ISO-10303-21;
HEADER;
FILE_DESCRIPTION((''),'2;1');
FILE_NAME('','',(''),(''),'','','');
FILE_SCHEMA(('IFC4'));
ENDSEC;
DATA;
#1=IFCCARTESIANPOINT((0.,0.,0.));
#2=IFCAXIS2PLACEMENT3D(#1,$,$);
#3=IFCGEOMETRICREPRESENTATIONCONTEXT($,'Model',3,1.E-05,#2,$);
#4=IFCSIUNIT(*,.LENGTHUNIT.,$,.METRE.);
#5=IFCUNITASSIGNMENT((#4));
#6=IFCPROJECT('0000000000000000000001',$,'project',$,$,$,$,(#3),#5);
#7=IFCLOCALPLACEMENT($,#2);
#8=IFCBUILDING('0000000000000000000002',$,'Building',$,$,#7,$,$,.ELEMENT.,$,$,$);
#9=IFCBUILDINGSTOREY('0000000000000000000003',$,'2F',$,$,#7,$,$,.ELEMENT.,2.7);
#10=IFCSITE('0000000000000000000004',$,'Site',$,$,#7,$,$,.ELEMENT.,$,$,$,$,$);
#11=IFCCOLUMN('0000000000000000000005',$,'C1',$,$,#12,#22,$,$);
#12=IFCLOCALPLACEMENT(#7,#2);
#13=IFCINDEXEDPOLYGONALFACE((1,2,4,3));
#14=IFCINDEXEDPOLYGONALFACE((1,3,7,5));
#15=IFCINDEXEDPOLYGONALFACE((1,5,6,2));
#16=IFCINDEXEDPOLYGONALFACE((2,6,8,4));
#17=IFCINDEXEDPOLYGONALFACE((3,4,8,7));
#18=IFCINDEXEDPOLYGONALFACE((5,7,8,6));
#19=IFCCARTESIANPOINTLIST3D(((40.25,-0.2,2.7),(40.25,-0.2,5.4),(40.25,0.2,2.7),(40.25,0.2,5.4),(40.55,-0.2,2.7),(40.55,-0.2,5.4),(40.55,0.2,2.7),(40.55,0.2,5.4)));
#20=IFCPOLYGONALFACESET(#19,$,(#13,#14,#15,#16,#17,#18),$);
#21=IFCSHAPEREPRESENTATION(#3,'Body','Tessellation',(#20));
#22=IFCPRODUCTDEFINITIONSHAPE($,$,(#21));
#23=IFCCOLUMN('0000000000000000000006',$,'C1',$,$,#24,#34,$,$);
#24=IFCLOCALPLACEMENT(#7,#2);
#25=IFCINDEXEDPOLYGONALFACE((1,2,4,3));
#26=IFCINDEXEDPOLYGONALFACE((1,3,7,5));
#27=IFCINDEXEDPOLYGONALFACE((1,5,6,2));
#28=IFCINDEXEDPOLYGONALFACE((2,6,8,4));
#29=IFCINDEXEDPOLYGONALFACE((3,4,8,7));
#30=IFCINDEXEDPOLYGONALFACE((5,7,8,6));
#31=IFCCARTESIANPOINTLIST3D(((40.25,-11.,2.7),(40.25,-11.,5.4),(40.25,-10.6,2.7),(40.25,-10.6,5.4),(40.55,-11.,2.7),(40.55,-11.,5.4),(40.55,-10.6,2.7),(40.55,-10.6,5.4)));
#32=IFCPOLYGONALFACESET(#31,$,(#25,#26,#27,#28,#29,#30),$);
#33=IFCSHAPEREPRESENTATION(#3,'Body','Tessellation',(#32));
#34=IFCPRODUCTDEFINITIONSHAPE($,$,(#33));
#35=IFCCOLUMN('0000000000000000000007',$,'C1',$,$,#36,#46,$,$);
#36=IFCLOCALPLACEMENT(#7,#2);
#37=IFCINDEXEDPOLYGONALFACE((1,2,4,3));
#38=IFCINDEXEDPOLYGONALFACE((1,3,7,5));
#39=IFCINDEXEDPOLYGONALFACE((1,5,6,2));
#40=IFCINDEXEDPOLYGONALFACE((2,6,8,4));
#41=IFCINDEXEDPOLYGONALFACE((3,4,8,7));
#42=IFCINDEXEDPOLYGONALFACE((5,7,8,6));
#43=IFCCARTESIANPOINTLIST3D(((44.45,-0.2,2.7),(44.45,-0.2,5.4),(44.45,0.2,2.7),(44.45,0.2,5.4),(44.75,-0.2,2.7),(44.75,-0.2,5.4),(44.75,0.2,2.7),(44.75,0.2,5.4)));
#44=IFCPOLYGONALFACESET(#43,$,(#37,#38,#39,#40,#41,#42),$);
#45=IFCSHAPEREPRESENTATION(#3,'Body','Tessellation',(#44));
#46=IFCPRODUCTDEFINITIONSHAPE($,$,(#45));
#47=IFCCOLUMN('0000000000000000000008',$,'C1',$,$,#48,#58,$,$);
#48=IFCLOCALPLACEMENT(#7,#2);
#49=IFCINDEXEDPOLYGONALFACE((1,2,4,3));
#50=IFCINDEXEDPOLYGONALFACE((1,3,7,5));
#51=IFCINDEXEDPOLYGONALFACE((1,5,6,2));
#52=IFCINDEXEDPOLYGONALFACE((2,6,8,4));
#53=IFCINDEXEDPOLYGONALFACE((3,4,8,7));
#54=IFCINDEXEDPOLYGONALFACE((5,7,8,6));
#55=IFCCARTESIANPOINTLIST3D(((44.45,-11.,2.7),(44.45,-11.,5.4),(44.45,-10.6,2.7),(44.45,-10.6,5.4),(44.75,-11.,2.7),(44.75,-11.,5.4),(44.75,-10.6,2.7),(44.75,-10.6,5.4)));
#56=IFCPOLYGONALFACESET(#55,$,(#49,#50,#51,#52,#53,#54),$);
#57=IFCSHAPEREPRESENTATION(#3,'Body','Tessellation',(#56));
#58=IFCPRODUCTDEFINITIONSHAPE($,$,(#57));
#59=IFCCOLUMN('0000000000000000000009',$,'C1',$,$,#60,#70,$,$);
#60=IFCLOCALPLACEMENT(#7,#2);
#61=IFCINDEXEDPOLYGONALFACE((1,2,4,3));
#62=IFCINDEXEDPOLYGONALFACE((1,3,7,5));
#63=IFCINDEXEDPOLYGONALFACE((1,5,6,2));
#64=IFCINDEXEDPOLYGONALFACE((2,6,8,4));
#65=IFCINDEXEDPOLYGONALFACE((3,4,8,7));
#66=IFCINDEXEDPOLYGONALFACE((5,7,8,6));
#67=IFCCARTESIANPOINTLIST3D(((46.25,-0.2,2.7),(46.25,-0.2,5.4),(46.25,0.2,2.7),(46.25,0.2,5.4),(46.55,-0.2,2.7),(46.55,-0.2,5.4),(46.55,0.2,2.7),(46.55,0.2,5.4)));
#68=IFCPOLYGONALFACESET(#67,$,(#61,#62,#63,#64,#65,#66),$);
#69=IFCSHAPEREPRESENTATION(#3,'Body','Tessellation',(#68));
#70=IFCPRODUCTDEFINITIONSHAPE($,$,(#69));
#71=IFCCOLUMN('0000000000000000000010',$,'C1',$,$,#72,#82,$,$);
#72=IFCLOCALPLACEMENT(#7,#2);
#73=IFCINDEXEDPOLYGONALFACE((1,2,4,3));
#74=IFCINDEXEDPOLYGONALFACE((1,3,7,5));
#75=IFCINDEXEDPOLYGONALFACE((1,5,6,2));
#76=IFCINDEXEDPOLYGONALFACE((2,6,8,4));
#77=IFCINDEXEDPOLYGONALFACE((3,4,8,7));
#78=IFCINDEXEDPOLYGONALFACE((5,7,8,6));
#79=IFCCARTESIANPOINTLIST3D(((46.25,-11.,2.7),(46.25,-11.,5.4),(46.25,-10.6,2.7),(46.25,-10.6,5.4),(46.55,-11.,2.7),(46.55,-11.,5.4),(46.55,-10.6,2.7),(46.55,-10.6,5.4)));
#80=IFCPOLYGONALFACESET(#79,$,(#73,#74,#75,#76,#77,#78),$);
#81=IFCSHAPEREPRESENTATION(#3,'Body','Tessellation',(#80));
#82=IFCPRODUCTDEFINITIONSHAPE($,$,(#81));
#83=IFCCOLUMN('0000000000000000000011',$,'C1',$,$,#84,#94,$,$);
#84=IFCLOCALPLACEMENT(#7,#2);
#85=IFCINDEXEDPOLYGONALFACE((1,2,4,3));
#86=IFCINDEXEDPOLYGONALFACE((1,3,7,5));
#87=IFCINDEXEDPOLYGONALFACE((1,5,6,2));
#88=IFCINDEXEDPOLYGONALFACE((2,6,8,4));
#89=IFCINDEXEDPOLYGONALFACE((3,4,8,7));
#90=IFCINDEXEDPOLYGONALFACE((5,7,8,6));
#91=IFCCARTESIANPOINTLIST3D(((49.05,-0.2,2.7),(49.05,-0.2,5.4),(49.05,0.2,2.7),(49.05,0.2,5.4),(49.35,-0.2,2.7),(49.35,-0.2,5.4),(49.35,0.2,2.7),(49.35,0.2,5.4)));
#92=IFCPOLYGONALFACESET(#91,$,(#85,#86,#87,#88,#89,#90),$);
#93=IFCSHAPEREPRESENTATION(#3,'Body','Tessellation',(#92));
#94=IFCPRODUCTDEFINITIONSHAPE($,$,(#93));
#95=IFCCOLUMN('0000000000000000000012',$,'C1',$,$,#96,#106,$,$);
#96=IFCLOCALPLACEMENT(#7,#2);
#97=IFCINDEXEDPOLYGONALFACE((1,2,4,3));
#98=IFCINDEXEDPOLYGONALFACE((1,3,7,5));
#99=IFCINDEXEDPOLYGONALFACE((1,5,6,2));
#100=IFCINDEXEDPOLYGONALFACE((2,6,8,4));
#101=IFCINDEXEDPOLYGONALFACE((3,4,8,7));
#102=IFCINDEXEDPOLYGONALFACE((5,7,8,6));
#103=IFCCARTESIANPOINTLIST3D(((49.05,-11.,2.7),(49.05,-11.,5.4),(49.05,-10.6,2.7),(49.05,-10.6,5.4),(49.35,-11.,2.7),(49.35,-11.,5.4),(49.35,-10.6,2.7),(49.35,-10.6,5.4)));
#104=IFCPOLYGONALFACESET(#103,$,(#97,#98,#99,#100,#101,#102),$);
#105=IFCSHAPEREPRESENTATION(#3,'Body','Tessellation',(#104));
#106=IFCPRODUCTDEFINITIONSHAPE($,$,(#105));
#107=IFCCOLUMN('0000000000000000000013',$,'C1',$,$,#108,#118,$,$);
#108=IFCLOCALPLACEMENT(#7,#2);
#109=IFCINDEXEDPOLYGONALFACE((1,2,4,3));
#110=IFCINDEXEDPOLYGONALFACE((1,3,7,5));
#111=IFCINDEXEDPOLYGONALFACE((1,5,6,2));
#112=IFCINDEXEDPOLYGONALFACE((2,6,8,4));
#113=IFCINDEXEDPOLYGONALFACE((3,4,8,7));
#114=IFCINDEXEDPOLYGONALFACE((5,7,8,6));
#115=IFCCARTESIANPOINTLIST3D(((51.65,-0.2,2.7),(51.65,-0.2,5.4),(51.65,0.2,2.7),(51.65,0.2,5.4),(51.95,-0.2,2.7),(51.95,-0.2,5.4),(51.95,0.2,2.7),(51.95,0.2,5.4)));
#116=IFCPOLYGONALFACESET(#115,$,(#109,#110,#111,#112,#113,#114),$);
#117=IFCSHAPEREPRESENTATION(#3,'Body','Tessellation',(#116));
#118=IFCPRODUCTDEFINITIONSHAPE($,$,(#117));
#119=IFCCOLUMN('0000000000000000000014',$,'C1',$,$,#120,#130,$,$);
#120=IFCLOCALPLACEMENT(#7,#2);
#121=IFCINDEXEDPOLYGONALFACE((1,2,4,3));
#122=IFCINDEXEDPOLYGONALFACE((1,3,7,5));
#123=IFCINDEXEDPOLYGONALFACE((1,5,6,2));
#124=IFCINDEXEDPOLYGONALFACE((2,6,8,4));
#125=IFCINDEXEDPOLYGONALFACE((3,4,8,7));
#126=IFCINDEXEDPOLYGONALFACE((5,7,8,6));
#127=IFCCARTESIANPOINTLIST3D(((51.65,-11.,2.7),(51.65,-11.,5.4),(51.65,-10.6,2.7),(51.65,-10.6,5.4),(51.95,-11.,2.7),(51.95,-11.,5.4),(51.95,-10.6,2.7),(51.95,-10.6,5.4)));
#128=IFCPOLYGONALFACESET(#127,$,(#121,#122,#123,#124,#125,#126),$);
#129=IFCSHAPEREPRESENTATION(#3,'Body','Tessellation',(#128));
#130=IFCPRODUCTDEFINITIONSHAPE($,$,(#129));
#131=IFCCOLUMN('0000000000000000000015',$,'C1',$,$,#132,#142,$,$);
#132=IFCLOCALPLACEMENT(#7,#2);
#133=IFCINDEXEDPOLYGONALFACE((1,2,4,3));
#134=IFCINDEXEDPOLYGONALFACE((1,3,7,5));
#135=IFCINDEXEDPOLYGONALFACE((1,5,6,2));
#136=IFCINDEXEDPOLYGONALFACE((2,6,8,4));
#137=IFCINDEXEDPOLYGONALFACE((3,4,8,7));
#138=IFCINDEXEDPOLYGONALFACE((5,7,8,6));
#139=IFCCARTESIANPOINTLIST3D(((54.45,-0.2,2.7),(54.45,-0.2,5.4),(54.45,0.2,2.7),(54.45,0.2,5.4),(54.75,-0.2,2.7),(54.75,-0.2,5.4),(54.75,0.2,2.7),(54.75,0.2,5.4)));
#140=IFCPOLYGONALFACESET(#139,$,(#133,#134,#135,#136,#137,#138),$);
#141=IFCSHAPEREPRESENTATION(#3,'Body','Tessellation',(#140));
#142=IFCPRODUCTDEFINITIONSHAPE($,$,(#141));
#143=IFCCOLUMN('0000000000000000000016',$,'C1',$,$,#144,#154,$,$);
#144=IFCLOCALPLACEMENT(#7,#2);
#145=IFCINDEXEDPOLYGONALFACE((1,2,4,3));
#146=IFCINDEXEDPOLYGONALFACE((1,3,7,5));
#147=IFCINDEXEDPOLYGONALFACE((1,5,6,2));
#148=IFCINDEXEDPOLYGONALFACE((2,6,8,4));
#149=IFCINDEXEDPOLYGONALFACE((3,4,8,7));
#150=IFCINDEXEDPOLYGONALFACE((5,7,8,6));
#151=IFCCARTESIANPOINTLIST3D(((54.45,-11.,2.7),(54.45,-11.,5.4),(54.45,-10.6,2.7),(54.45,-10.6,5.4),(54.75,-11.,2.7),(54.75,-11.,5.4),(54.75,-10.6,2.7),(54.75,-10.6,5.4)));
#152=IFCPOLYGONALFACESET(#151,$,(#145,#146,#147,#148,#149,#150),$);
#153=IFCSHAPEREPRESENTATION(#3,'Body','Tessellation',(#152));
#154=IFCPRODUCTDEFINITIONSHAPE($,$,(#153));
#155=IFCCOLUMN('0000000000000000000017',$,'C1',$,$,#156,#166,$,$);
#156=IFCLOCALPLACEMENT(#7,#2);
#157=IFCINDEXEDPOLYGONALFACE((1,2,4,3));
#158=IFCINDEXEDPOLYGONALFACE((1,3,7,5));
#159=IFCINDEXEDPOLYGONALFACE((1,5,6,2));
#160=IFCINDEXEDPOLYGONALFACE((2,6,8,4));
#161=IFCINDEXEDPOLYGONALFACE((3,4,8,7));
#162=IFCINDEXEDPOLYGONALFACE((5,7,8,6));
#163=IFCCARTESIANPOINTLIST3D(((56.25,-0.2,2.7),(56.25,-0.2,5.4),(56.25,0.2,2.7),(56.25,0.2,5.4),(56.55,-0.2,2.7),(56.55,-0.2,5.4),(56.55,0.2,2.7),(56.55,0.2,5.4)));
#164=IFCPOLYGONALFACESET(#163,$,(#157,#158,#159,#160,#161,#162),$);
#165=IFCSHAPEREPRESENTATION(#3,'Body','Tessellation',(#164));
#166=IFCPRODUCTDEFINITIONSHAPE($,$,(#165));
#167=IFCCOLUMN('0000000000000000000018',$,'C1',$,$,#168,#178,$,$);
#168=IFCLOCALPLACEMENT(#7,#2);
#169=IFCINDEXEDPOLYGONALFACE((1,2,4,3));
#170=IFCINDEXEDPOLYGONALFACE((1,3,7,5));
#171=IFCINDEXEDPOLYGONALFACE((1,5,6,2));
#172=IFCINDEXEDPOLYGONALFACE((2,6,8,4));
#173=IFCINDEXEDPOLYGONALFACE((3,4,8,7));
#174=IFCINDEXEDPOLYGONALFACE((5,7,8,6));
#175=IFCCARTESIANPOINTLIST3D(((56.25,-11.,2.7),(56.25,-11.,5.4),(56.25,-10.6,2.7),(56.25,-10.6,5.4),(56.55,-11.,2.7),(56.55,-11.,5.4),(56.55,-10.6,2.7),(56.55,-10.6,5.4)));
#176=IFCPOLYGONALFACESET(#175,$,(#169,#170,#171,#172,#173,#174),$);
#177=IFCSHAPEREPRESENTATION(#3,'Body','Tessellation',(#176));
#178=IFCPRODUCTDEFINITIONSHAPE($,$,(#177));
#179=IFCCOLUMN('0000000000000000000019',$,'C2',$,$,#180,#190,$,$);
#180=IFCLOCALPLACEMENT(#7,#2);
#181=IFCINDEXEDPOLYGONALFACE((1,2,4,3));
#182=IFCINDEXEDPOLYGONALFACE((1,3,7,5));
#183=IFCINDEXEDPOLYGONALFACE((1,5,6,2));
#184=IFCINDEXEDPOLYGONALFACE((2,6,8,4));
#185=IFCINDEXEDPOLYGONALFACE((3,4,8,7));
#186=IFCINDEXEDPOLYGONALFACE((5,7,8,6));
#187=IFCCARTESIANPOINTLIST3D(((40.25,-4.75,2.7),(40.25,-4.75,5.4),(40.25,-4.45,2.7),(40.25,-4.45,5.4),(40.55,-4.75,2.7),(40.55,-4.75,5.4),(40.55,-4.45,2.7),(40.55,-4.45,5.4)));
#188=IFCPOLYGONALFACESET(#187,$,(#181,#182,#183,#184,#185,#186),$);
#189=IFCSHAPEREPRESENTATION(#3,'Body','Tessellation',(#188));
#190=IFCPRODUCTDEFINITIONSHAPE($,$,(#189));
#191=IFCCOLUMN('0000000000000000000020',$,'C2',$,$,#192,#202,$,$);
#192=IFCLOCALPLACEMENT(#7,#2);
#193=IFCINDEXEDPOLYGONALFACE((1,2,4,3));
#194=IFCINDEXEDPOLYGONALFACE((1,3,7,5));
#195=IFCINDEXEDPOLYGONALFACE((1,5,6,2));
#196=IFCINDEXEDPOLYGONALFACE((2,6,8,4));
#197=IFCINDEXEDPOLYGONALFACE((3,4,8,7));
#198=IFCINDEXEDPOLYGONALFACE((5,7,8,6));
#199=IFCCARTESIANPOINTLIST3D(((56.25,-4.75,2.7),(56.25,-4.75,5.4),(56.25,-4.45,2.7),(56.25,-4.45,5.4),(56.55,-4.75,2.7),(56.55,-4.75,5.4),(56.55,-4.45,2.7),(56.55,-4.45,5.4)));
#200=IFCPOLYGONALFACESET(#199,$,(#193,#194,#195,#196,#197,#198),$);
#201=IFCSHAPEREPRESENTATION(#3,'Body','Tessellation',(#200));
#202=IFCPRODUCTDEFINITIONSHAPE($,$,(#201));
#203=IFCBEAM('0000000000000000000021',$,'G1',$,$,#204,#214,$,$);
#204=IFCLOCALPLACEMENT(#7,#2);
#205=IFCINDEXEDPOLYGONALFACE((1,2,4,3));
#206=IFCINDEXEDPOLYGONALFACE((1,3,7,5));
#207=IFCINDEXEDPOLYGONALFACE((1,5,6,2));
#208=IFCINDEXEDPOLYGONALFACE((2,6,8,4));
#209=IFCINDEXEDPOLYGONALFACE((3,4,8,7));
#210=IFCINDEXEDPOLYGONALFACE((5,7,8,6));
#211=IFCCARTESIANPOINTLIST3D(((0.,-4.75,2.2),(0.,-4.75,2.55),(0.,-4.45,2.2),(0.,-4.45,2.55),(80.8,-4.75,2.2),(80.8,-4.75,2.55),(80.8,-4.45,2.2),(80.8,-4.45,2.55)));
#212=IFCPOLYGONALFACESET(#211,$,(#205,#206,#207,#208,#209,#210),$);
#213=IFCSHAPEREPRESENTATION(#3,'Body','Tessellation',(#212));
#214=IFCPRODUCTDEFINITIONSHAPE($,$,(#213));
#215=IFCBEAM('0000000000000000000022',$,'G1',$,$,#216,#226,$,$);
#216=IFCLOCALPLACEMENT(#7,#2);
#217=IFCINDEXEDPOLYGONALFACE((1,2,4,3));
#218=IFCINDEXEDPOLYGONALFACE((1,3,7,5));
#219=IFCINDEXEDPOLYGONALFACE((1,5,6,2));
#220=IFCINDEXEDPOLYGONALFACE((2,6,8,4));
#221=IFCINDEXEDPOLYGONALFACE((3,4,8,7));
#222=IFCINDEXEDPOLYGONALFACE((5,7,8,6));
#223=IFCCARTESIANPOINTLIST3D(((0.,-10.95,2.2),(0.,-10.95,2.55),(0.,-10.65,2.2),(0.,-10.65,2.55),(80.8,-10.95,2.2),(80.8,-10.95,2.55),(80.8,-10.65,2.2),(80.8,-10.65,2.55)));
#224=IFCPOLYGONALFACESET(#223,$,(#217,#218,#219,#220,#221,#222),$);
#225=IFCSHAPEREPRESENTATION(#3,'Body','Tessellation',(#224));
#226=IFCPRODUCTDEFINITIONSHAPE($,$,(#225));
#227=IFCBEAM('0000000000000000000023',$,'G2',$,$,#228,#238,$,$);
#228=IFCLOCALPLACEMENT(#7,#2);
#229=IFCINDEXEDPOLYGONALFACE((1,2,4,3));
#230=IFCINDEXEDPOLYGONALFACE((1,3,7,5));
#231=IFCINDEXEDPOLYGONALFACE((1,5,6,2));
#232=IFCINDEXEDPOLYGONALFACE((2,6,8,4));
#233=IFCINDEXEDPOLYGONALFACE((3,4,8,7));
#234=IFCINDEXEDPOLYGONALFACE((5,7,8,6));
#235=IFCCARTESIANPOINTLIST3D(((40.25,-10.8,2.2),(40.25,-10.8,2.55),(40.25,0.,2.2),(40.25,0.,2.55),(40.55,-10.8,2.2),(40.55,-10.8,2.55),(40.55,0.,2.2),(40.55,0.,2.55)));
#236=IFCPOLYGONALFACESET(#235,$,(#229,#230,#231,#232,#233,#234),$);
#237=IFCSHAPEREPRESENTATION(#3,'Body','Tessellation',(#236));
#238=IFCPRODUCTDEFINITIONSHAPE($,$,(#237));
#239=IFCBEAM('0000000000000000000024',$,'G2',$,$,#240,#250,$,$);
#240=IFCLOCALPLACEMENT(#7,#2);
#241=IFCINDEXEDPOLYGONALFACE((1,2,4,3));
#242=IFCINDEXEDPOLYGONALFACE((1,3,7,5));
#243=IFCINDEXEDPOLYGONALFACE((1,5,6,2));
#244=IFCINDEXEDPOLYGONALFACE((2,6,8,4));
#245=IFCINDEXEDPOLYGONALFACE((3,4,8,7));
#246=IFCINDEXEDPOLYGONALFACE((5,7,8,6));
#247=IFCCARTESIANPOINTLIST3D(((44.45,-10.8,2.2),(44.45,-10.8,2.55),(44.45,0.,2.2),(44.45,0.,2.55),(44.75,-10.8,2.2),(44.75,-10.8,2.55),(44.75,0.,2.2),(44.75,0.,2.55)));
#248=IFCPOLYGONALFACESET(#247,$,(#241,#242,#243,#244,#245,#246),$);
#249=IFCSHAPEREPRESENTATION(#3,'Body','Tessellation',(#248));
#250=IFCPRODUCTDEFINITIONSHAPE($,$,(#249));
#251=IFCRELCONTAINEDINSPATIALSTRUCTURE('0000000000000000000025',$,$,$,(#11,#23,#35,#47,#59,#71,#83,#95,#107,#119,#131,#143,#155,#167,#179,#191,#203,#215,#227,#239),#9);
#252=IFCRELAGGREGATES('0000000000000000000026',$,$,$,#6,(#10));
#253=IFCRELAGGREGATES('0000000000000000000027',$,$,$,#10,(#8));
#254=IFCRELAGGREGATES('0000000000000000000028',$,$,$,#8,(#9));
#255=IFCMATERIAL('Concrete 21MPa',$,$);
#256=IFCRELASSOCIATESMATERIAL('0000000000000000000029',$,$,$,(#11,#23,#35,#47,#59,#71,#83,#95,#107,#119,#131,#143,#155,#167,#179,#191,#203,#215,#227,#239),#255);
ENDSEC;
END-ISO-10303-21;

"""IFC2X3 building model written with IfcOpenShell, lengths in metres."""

from ifc_helpers import new_model, si_unit, frame, origin, origin_2d, place, context, project, spatial, rectangle, extrude, material, element, save


model = new_model("IFC2X3")

# Units and contexts
model_context = context("Model", 3, precision=1e-05, world=origin())
ifc_project = project(units=[si_unit("LENGTHUNIT", "METRE")], contexts=[model_context])

# Site, building, storey
placement = place(None, origin())
site = spatial("IfcSite", under=ifc_project, at=placement, Name="Site", CompositionType="ELEMENT")
building = spatial("IfcBuilding", under=site, at=placement, Name="Building", CompositionType="ELEMENT")
storey = spatial("IfcBuildingStorey", under=building, at=placement, Name="2F", CompositionType="ELEMENT", Elevation=2.7)

# Columns
ifc_material = material(Name="Concrete 21MPa")
for number, where, name in (
    (1, (40.4, 0.0, 2.7), "C1"),
    (2, (40.4, -10.8, 2.7), "C1"),
    (3, (44.6, 0.0, 2.7), "C1"),
    (4, (44.6, -10.8, 2.7), "C1"),
    (5, (46.4, 0.0, 2.7), "C1"),
    (6, (46.4, -10.8, 2.7), "C1"),
    (7, (49.2, 0.0, 2.7), "C1"),
    (8, (49.2, -10.8, 2.7), "C1"),
    (9, (51.8, 0.0, 2.7), "C1"),
    (10, (51.8, -10.8, 2.7), "C1"),
    (11, (54.6, 0.0, 2.7), "C1"),
    (12, (54.6, -10.8, 2.7), "C1"),
    (13, (56.4, 0.0, 2.7), "C1"),
    (14, (56.4, -10.8, 2.7), "C1"),
):
    element("IfcColumn", number, at=place(None, frame(where)), inside=storey, material=ifc_material, Name=name, context=model_context, shape_type="SweptSolid", body=[
        extrude(rectangle(XDim=0.3, YDim=0.4, at=origin_2d()), origin(), (0.0, 0.0, 1.0), 2.7),
    ])
for number, where, name in (
    (15, (40.4, -4.6, 2.7), "C2"),
    (16, (56.4, -4.6, 2.7), "C2"),
):
    element("IfcColumn", number, at=place(None, frame(where)), inside=storey, material=ifc_material, Name=name, context=model_context, shape_type="SweptSolid", body=[
        extrude(rectangle(XDim=0.3, YDim=0.3, at=origin_2d()), origin(), (0.0, 0.0, 1.0), 2.7),
    ])

# Beams
for number, where, name in (
    (17, (40.4, -4.6, 2.2), "G1"),
    (18, (40.4, -10.8, 2.2), "G1"),
):
    element("IfcBeam", number, at=place(None, frame(where)), inside=storey, material=ifc_material, Name=name, context=model_context, shape_type="SweptSolid", body=[
        extrude(rectangle(XDim=80.8, YDim=0.3, at=origin_2d()), origin(), (0.0, 0.0, 1.0), 0.35),
    ])
for number, where, name in (
    (19, (40.4, -5.4, 2.2), "G2"),
    (20, (44.6, -5.4, 2.2), "G2"),
):
    element("IfcBeam", number, at=place(None, frame(where)), inside=storey, material=ifc_material, Name=name, context=model_context, shape_type="SweptSolid", body=[
        extrude(rectangle(XDim=0.3, YDim=10.8, at=origin_2d()), origin(), (0.0, 0.0, 1.0), 0.35),
    ])

save(model, "model.ifc")
